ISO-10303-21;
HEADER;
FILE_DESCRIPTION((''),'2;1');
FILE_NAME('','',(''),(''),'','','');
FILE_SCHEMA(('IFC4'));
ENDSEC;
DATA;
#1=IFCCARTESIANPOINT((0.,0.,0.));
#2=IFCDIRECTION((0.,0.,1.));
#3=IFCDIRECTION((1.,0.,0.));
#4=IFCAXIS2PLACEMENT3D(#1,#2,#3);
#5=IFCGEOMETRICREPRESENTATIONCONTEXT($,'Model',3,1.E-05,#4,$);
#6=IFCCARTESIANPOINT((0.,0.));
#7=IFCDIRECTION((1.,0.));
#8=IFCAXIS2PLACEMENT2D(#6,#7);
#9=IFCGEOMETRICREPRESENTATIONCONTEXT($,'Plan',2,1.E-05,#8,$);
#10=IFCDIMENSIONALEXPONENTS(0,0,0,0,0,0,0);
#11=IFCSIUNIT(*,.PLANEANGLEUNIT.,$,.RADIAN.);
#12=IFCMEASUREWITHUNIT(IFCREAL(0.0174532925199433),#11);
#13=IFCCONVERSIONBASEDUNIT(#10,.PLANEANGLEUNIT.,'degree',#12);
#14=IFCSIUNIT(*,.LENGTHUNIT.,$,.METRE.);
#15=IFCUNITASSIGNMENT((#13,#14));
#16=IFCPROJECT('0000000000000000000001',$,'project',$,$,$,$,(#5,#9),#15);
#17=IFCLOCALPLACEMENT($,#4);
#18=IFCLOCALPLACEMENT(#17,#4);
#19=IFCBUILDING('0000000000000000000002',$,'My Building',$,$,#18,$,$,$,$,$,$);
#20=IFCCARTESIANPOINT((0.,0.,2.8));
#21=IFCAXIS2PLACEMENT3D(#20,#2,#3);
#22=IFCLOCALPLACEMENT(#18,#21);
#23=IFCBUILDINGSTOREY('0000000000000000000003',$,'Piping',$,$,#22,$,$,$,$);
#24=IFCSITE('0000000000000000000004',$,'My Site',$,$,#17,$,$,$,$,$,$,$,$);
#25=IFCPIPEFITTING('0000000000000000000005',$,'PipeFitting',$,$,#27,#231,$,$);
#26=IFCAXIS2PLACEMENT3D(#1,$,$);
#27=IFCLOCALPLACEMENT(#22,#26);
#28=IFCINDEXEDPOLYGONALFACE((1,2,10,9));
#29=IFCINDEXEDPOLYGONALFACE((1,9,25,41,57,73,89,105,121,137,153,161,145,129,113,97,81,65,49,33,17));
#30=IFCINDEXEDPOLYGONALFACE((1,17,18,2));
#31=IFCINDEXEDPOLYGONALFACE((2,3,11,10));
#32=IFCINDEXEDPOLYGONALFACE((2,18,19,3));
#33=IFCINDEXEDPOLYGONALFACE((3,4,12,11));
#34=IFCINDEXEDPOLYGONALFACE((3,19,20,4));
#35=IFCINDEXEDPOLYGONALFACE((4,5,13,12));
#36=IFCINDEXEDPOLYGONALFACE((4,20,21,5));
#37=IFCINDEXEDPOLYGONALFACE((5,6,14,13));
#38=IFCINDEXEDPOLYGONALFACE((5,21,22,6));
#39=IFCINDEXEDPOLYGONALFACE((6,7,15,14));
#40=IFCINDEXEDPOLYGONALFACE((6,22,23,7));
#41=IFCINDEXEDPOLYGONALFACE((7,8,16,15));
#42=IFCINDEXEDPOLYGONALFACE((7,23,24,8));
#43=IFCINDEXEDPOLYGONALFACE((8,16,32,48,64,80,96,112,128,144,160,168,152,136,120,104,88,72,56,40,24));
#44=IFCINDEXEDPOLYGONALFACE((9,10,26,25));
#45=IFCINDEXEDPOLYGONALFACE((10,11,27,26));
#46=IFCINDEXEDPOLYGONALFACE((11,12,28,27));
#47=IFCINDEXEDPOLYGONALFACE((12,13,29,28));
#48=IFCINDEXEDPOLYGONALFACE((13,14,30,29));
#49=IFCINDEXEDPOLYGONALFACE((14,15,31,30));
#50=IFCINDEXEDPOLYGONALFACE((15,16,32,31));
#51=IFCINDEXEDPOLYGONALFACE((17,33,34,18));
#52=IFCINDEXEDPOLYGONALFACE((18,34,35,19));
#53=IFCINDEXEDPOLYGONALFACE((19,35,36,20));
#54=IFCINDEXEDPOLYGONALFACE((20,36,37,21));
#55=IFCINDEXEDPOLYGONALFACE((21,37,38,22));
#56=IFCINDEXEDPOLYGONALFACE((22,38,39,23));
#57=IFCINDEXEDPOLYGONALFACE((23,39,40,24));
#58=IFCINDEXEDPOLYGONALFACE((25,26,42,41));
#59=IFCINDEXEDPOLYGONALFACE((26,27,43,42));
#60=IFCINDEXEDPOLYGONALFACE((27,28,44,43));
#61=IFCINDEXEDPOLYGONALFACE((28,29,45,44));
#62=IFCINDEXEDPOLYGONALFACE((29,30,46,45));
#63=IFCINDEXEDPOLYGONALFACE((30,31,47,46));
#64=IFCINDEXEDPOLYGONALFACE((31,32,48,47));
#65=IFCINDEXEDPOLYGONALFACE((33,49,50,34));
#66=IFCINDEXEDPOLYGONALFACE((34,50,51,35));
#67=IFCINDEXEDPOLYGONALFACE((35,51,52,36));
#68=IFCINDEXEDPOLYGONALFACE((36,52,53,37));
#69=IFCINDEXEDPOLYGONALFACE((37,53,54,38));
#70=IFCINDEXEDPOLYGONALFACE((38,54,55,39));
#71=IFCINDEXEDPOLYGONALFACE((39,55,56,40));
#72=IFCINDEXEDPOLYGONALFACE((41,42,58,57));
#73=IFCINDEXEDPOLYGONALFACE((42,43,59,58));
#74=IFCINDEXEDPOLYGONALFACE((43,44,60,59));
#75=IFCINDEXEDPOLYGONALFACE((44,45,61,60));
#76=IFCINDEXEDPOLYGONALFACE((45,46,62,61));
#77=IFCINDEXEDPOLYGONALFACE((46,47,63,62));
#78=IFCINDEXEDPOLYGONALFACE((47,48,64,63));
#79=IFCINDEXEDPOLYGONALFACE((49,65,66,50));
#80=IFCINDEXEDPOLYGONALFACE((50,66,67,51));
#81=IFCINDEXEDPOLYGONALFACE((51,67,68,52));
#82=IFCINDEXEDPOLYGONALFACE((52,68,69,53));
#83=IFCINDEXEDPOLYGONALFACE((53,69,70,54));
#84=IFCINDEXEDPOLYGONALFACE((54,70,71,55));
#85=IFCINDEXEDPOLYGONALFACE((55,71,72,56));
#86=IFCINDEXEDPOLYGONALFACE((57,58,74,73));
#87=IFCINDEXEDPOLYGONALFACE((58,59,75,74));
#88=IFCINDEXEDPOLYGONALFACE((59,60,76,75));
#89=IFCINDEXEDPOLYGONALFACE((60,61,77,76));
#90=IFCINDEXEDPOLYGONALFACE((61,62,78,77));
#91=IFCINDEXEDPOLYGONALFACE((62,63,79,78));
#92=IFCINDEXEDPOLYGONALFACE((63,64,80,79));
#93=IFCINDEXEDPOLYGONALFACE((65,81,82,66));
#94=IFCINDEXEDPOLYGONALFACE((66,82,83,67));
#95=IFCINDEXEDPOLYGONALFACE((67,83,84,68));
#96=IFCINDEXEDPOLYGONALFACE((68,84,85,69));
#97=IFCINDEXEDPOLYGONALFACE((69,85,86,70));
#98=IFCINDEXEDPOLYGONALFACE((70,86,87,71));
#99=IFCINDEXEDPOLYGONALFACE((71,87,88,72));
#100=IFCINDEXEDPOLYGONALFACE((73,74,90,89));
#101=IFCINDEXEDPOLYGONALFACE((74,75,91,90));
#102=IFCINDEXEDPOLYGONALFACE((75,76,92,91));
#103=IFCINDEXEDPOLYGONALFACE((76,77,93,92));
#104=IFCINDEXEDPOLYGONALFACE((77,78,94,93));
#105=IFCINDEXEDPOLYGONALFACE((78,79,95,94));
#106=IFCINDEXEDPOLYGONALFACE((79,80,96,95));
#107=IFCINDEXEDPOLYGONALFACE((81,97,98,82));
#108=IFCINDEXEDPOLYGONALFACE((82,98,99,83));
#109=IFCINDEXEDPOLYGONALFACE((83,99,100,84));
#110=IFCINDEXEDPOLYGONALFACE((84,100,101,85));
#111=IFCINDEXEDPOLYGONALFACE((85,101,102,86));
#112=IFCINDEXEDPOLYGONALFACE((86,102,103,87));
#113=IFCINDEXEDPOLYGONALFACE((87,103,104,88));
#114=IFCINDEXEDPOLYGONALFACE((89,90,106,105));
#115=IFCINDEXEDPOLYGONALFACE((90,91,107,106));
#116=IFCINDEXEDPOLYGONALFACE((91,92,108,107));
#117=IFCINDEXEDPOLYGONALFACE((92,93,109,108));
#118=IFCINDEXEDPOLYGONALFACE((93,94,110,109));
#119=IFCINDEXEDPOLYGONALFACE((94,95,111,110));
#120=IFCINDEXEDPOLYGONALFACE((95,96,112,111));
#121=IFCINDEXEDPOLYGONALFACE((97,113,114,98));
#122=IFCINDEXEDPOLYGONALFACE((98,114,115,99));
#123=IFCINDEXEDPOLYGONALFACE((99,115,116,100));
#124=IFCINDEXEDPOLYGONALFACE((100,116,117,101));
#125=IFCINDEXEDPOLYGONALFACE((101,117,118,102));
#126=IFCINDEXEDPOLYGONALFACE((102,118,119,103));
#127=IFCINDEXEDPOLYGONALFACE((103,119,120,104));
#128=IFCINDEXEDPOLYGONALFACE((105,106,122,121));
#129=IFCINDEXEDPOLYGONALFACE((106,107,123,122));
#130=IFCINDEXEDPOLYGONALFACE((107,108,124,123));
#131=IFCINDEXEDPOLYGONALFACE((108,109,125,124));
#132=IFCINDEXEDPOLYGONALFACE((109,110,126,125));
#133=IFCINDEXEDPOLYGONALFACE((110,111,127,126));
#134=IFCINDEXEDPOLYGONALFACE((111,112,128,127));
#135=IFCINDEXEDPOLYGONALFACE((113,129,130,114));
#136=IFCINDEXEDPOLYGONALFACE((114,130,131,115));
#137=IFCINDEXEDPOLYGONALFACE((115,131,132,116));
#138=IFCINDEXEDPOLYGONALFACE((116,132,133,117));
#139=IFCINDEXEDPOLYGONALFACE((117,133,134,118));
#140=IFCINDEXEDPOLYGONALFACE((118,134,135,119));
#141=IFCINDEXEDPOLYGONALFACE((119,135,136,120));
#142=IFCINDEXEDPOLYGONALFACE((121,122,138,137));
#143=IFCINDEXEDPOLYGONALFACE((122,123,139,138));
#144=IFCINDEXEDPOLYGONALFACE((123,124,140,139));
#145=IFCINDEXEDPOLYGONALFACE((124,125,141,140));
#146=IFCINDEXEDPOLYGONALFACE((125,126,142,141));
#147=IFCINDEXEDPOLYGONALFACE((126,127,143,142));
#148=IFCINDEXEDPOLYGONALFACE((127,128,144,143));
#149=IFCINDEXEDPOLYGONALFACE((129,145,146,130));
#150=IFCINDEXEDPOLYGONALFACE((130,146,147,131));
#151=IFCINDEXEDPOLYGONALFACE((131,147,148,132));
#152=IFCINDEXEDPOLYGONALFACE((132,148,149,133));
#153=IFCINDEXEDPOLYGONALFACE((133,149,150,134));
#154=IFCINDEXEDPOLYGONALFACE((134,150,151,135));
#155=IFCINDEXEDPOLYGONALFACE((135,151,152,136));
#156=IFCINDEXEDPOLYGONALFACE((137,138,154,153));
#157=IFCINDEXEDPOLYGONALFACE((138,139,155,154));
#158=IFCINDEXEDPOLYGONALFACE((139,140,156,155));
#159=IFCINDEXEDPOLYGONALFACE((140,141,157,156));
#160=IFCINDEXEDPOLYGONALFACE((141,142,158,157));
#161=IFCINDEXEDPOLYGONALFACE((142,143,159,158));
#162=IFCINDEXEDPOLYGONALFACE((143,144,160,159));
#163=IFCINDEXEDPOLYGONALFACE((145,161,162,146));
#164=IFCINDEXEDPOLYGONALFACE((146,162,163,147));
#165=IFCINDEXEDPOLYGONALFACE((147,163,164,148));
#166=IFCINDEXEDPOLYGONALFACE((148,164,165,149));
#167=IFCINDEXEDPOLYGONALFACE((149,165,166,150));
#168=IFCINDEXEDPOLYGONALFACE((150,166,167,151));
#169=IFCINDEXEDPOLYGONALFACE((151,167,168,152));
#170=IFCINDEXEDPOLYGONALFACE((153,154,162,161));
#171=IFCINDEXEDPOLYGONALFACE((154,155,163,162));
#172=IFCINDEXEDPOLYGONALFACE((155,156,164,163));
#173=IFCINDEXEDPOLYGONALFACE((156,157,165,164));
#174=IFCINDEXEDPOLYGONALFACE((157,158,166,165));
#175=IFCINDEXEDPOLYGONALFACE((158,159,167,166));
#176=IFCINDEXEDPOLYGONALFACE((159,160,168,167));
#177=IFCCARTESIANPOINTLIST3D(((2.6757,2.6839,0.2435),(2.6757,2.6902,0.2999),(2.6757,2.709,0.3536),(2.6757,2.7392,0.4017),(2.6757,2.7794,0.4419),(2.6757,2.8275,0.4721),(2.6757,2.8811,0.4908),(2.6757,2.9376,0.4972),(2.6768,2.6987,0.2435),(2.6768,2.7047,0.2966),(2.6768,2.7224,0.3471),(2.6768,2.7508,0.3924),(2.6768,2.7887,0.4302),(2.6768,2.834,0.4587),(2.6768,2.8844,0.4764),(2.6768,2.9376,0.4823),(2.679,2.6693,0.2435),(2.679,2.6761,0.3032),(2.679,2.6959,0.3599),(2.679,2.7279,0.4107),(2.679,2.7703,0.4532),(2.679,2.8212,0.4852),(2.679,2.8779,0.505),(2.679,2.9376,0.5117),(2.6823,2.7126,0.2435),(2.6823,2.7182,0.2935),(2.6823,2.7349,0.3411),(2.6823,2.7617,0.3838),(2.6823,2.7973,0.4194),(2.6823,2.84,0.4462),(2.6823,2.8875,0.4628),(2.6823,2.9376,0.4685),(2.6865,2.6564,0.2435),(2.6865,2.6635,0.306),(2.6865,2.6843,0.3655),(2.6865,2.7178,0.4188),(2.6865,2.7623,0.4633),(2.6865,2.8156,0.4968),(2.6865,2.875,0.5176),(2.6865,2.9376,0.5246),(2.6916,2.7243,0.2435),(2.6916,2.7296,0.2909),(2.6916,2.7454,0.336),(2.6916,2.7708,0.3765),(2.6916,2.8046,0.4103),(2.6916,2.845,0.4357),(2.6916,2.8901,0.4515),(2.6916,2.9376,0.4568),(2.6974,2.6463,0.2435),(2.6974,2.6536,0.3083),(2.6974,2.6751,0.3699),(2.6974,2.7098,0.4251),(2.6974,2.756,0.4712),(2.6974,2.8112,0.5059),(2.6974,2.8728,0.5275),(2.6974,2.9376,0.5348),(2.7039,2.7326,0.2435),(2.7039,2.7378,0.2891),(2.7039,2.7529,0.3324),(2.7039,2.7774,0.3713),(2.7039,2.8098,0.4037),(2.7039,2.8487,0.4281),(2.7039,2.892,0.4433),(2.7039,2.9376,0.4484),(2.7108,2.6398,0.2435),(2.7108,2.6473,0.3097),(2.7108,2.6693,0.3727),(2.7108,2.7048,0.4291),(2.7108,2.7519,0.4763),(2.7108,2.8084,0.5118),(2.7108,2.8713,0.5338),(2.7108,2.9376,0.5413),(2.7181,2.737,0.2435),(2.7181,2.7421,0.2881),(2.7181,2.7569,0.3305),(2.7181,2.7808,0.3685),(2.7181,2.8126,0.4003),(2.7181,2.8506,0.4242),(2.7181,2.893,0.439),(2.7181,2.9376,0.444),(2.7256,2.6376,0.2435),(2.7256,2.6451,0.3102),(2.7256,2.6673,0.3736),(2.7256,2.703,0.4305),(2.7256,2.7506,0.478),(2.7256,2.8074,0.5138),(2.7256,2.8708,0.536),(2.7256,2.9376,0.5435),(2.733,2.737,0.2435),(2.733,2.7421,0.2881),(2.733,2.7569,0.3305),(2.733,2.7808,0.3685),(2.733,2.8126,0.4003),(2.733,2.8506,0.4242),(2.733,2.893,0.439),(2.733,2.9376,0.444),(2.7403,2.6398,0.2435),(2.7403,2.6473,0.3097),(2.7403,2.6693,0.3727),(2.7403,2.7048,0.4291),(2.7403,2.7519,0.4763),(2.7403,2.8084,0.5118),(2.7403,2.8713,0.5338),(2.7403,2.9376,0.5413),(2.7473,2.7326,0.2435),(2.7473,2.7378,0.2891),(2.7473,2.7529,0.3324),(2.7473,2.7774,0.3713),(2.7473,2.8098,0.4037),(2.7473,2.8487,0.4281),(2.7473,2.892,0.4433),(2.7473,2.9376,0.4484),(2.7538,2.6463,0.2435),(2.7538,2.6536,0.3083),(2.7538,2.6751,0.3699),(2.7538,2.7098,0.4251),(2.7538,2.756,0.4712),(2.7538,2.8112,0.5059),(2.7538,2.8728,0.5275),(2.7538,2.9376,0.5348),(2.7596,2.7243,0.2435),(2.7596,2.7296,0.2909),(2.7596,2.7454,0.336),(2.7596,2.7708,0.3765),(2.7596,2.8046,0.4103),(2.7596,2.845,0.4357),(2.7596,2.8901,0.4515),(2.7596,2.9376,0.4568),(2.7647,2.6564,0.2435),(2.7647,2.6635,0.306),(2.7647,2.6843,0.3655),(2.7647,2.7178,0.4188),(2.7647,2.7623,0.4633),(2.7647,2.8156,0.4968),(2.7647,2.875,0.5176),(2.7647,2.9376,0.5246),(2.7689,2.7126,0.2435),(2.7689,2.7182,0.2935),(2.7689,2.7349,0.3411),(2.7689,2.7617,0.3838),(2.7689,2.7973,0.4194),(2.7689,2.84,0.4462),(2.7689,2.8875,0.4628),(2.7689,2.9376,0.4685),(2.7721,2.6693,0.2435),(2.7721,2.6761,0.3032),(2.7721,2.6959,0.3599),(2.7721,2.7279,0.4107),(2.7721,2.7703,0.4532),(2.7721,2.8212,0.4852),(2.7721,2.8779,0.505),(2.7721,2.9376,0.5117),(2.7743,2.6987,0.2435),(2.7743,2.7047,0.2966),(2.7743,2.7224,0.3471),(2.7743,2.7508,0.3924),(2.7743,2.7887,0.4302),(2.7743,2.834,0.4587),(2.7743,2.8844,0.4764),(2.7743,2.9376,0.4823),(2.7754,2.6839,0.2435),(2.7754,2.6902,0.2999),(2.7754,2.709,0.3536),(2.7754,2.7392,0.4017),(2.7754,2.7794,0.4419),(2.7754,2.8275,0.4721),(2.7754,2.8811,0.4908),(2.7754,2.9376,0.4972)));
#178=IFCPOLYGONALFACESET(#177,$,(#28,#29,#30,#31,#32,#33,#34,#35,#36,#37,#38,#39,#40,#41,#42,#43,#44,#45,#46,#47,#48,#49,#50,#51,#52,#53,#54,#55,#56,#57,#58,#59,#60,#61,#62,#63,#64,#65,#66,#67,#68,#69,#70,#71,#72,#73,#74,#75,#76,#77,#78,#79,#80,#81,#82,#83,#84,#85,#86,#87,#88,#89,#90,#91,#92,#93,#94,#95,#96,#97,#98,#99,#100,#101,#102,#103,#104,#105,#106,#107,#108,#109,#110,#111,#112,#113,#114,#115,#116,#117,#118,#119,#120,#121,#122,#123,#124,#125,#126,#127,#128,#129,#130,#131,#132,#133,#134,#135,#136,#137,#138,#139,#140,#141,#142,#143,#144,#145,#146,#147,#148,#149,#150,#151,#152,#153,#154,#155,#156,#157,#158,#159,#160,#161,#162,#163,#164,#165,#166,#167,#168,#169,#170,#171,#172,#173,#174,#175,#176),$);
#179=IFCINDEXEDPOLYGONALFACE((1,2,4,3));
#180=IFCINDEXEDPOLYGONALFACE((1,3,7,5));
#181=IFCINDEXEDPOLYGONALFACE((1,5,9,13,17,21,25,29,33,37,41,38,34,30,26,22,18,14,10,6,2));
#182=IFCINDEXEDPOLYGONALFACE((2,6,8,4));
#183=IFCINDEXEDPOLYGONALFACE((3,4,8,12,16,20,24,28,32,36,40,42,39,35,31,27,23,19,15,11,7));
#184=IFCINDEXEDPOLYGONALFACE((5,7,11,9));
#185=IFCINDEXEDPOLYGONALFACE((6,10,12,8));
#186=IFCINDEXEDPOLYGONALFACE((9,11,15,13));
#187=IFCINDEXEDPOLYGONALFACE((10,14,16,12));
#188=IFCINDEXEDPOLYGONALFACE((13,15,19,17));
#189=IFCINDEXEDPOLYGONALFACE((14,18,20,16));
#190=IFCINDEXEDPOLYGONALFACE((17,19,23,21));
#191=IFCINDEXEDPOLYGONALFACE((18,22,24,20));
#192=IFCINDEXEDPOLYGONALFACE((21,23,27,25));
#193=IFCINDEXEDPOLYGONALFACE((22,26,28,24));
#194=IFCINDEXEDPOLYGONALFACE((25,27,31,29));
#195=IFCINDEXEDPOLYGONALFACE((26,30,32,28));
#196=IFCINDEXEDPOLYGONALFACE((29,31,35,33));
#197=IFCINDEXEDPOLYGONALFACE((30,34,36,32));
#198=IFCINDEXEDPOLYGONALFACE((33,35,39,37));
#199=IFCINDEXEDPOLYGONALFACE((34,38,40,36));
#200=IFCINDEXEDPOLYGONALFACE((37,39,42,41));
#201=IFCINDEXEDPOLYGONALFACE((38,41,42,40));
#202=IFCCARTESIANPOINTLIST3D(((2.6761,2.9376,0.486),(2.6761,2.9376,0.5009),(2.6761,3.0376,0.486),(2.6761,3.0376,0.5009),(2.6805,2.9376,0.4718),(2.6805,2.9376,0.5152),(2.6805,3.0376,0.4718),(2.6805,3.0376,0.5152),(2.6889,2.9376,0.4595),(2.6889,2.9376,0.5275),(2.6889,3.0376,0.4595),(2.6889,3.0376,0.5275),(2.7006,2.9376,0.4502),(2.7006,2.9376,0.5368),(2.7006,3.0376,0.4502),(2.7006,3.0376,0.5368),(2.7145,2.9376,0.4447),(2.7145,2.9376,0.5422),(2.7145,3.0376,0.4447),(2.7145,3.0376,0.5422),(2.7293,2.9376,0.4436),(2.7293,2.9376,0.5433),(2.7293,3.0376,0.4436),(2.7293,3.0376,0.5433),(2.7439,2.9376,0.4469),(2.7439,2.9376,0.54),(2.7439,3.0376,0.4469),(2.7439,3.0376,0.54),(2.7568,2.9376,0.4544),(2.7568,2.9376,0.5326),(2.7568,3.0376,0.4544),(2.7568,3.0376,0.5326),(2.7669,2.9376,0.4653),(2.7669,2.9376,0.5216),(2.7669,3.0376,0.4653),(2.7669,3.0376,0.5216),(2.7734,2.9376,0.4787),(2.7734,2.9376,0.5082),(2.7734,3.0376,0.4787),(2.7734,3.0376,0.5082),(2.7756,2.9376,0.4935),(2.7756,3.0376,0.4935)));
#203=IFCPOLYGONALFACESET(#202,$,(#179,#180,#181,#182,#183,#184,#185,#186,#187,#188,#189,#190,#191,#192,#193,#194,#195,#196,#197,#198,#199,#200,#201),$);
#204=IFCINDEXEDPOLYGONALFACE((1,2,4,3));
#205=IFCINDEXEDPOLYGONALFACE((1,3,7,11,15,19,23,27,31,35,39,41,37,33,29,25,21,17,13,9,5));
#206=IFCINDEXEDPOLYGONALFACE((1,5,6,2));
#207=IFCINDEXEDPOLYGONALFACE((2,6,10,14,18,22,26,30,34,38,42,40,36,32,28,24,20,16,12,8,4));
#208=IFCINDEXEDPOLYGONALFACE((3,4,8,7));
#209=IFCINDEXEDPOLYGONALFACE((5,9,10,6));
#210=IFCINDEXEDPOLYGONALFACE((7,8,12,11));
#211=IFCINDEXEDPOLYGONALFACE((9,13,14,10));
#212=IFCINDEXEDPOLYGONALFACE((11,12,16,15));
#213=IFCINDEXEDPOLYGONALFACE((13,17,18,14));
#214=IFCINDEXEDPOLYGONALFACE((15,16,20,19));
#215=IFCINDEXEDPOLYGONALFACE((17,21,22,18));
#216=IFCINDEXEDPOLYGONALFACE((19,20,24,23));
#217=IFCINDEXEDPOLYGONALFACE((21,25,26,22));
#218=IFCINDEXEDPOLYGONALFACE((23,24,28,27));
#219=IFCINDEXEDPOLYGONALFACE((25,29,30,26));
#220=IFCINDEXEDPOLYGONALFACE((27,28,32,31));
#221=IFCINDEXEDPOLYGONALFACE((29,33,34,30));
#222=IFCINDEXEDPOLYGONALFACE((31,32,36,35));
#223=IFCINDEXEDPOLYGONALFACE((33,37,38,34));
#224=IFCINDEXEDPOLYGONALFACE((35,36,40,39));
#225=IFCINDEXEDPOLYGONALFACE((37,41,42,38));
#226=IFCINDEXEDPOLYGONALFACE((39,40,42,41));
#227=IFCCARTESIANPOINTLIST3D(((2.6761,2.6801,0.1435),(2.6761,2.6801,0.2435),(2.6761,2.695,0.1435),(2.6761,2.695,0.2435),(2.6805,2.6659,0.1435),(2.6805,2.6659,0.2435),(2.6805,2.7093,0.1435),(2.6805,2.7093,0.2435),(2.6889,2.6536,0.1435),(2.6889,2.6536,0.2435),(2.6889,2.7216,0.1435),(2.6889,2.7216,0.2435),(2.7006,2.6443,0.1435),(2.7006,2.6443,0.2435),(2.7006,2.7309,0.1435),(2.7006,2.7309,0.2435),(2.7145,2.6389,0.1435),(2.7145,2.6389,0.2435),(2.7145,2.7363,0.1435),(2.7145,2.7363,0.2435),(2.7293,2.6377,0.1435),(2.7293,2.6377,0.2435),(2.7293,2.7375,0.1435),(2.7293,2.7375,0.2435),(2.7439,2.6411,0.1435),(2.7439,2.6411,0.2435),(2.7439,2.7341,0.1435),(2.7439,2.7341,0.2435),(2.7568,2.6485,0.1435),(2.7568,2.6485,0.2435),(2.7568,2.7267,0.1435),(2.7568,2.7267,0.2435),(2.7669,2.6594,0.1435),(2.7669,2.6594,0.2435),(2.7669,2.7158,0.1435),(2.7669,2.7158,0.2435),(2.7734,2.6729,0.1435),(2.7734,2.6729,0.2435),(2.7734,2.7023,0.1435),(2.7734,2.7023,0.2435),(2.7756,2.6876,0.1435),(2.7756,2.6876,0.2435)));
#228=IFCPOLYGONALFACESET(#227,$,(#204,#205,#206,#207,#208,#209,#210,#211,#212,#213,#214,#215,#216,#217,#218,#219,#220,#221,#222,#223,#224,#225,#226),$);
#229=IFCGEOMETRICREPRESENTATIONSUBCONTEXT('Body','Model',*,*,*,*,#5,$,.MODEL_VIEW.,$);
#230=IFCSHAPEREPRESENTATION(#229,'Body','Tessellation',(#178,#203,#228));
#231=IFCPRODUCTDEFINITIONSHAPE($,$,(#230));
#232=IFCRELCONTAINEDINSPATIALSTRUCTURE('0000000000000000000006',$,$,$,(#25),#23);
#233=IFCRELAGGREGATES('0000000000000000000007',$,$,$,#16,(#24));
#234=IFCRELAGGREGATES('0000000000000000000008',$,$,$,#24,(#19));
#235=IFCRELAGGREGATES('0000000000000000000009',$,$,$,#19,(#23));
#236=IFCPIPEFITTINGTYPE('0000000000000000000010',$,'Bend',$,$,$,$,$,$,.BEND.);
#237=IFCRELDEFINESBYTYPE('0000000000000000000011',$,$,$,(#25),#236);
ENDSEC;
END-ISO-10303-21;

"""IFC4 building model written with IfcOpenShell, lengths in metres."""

from ifc_helpers import new_model, entity, si_unit, converted_unit, frame, origin_with_axes, origin_2d_with_axis, place, context, subcontext, project, spatial, circle, extrude, source, transform, mapped, type_object, type_shapes, element, save


model = new_model("IFC4")

# Units and contexts
model_context = context("Model", 3, precision=1e-05, world=origin_with_axes())
plan_context = context("Plan", 2, precision=1e-05, world=origin_2d_with_axis())
body_context = subcontext(model_context, "Body", "Model", "MODEL_VIEW")
ifc_project = project(units=[converted_unit("PLANEANGLEUNIT", "degree", entity("IfcReal", 0.0174532925199433), si_unit("PLANEANGLEUNIT", "RADIAN"), dimensions=[0, 0, 0, 0, 0, 0, 0]), si_unit("LENGTHUNIT", "METRE")], contexts=[model_context, plan_context])

# Site, building, storey
site_placement = place(None, origin_with_axes())
site = spatial("IfcSite", under=ifc_project, at=site_placement, Name="My Site")
building_placement = place(site_placement, origin_with_axes())
building = spatial("IfcBuilding", under=site, at=building_placement, Name="My Building")
storey_placement = place(building_placement, frame((0.0, 0.0, 2.8), z_axis=(0.0, 0.0, 1.0), x_axis=(1.0, 0.0, 0.0)))
storey = spatial("IfcBuildingStorey", under=building, at=storey_placement, Name="Piping")

# Pipe fitting
pipe_fitting_type_1 = type_object("IfcPipeFittingType", Name="Bend", PredefinedType="BEND")
shared_shape_1 = source(origin_with_axes(), body_context, "Body", "SolidModel", [
    entity("IfcSweptDiskSolid", entity("IfcIndexedPolyCurve", entity("IfcCartesianPointList3D", [[0.0, 0.0, 0.1], [0.0, -0.0732, 0.2768], [0.0, -0.25, 0.35]]), [entity("IfcArcIndex", [1, 2, 3])]), 0.05),
    extrude(circle(Radius=0.05), origin_with_axes(), (0.0, 0.0, 1.0), 0.1),
    extrude(circle(Radius=0.05), frame((0.0, -0.25, 0.35), z_axis=(0.0, -1.0, 0.0), x_axis=(1.0, 0.0, 0.0)), (0.0, 0.0, 1.0), 0.1),
])
type_shapes(pipe_fitting_type_1, [shared_shape_1])
for number, where, z_axis, x_axis, name in (
    (1, (2.7256, 3.0376, 0.4935), (0.0, -1.0, 0.0), (1.0, 0.0, 0.0), "PipeFitting"),
):
    element("IfcPipeFitting", number, at=place(storey_placement, frame(where, z_axis=z_axis, x_axis=x_axis)), inside=storey, type_object=pipe_fitting_type_1, Name=name, context=body_context, shape_type="MappedRepresentation", body=[
        mapped(shared_shape_1, transform((0.0, 0.0, 0.0), x_axis=(1.0, 0.0, 0.0), y_axis=(0.0, 1.0, 0.0), z_axis=(0.0, 0.0, 1.0), scale=1.0)),
    ])

save(model, "model.ifc")
